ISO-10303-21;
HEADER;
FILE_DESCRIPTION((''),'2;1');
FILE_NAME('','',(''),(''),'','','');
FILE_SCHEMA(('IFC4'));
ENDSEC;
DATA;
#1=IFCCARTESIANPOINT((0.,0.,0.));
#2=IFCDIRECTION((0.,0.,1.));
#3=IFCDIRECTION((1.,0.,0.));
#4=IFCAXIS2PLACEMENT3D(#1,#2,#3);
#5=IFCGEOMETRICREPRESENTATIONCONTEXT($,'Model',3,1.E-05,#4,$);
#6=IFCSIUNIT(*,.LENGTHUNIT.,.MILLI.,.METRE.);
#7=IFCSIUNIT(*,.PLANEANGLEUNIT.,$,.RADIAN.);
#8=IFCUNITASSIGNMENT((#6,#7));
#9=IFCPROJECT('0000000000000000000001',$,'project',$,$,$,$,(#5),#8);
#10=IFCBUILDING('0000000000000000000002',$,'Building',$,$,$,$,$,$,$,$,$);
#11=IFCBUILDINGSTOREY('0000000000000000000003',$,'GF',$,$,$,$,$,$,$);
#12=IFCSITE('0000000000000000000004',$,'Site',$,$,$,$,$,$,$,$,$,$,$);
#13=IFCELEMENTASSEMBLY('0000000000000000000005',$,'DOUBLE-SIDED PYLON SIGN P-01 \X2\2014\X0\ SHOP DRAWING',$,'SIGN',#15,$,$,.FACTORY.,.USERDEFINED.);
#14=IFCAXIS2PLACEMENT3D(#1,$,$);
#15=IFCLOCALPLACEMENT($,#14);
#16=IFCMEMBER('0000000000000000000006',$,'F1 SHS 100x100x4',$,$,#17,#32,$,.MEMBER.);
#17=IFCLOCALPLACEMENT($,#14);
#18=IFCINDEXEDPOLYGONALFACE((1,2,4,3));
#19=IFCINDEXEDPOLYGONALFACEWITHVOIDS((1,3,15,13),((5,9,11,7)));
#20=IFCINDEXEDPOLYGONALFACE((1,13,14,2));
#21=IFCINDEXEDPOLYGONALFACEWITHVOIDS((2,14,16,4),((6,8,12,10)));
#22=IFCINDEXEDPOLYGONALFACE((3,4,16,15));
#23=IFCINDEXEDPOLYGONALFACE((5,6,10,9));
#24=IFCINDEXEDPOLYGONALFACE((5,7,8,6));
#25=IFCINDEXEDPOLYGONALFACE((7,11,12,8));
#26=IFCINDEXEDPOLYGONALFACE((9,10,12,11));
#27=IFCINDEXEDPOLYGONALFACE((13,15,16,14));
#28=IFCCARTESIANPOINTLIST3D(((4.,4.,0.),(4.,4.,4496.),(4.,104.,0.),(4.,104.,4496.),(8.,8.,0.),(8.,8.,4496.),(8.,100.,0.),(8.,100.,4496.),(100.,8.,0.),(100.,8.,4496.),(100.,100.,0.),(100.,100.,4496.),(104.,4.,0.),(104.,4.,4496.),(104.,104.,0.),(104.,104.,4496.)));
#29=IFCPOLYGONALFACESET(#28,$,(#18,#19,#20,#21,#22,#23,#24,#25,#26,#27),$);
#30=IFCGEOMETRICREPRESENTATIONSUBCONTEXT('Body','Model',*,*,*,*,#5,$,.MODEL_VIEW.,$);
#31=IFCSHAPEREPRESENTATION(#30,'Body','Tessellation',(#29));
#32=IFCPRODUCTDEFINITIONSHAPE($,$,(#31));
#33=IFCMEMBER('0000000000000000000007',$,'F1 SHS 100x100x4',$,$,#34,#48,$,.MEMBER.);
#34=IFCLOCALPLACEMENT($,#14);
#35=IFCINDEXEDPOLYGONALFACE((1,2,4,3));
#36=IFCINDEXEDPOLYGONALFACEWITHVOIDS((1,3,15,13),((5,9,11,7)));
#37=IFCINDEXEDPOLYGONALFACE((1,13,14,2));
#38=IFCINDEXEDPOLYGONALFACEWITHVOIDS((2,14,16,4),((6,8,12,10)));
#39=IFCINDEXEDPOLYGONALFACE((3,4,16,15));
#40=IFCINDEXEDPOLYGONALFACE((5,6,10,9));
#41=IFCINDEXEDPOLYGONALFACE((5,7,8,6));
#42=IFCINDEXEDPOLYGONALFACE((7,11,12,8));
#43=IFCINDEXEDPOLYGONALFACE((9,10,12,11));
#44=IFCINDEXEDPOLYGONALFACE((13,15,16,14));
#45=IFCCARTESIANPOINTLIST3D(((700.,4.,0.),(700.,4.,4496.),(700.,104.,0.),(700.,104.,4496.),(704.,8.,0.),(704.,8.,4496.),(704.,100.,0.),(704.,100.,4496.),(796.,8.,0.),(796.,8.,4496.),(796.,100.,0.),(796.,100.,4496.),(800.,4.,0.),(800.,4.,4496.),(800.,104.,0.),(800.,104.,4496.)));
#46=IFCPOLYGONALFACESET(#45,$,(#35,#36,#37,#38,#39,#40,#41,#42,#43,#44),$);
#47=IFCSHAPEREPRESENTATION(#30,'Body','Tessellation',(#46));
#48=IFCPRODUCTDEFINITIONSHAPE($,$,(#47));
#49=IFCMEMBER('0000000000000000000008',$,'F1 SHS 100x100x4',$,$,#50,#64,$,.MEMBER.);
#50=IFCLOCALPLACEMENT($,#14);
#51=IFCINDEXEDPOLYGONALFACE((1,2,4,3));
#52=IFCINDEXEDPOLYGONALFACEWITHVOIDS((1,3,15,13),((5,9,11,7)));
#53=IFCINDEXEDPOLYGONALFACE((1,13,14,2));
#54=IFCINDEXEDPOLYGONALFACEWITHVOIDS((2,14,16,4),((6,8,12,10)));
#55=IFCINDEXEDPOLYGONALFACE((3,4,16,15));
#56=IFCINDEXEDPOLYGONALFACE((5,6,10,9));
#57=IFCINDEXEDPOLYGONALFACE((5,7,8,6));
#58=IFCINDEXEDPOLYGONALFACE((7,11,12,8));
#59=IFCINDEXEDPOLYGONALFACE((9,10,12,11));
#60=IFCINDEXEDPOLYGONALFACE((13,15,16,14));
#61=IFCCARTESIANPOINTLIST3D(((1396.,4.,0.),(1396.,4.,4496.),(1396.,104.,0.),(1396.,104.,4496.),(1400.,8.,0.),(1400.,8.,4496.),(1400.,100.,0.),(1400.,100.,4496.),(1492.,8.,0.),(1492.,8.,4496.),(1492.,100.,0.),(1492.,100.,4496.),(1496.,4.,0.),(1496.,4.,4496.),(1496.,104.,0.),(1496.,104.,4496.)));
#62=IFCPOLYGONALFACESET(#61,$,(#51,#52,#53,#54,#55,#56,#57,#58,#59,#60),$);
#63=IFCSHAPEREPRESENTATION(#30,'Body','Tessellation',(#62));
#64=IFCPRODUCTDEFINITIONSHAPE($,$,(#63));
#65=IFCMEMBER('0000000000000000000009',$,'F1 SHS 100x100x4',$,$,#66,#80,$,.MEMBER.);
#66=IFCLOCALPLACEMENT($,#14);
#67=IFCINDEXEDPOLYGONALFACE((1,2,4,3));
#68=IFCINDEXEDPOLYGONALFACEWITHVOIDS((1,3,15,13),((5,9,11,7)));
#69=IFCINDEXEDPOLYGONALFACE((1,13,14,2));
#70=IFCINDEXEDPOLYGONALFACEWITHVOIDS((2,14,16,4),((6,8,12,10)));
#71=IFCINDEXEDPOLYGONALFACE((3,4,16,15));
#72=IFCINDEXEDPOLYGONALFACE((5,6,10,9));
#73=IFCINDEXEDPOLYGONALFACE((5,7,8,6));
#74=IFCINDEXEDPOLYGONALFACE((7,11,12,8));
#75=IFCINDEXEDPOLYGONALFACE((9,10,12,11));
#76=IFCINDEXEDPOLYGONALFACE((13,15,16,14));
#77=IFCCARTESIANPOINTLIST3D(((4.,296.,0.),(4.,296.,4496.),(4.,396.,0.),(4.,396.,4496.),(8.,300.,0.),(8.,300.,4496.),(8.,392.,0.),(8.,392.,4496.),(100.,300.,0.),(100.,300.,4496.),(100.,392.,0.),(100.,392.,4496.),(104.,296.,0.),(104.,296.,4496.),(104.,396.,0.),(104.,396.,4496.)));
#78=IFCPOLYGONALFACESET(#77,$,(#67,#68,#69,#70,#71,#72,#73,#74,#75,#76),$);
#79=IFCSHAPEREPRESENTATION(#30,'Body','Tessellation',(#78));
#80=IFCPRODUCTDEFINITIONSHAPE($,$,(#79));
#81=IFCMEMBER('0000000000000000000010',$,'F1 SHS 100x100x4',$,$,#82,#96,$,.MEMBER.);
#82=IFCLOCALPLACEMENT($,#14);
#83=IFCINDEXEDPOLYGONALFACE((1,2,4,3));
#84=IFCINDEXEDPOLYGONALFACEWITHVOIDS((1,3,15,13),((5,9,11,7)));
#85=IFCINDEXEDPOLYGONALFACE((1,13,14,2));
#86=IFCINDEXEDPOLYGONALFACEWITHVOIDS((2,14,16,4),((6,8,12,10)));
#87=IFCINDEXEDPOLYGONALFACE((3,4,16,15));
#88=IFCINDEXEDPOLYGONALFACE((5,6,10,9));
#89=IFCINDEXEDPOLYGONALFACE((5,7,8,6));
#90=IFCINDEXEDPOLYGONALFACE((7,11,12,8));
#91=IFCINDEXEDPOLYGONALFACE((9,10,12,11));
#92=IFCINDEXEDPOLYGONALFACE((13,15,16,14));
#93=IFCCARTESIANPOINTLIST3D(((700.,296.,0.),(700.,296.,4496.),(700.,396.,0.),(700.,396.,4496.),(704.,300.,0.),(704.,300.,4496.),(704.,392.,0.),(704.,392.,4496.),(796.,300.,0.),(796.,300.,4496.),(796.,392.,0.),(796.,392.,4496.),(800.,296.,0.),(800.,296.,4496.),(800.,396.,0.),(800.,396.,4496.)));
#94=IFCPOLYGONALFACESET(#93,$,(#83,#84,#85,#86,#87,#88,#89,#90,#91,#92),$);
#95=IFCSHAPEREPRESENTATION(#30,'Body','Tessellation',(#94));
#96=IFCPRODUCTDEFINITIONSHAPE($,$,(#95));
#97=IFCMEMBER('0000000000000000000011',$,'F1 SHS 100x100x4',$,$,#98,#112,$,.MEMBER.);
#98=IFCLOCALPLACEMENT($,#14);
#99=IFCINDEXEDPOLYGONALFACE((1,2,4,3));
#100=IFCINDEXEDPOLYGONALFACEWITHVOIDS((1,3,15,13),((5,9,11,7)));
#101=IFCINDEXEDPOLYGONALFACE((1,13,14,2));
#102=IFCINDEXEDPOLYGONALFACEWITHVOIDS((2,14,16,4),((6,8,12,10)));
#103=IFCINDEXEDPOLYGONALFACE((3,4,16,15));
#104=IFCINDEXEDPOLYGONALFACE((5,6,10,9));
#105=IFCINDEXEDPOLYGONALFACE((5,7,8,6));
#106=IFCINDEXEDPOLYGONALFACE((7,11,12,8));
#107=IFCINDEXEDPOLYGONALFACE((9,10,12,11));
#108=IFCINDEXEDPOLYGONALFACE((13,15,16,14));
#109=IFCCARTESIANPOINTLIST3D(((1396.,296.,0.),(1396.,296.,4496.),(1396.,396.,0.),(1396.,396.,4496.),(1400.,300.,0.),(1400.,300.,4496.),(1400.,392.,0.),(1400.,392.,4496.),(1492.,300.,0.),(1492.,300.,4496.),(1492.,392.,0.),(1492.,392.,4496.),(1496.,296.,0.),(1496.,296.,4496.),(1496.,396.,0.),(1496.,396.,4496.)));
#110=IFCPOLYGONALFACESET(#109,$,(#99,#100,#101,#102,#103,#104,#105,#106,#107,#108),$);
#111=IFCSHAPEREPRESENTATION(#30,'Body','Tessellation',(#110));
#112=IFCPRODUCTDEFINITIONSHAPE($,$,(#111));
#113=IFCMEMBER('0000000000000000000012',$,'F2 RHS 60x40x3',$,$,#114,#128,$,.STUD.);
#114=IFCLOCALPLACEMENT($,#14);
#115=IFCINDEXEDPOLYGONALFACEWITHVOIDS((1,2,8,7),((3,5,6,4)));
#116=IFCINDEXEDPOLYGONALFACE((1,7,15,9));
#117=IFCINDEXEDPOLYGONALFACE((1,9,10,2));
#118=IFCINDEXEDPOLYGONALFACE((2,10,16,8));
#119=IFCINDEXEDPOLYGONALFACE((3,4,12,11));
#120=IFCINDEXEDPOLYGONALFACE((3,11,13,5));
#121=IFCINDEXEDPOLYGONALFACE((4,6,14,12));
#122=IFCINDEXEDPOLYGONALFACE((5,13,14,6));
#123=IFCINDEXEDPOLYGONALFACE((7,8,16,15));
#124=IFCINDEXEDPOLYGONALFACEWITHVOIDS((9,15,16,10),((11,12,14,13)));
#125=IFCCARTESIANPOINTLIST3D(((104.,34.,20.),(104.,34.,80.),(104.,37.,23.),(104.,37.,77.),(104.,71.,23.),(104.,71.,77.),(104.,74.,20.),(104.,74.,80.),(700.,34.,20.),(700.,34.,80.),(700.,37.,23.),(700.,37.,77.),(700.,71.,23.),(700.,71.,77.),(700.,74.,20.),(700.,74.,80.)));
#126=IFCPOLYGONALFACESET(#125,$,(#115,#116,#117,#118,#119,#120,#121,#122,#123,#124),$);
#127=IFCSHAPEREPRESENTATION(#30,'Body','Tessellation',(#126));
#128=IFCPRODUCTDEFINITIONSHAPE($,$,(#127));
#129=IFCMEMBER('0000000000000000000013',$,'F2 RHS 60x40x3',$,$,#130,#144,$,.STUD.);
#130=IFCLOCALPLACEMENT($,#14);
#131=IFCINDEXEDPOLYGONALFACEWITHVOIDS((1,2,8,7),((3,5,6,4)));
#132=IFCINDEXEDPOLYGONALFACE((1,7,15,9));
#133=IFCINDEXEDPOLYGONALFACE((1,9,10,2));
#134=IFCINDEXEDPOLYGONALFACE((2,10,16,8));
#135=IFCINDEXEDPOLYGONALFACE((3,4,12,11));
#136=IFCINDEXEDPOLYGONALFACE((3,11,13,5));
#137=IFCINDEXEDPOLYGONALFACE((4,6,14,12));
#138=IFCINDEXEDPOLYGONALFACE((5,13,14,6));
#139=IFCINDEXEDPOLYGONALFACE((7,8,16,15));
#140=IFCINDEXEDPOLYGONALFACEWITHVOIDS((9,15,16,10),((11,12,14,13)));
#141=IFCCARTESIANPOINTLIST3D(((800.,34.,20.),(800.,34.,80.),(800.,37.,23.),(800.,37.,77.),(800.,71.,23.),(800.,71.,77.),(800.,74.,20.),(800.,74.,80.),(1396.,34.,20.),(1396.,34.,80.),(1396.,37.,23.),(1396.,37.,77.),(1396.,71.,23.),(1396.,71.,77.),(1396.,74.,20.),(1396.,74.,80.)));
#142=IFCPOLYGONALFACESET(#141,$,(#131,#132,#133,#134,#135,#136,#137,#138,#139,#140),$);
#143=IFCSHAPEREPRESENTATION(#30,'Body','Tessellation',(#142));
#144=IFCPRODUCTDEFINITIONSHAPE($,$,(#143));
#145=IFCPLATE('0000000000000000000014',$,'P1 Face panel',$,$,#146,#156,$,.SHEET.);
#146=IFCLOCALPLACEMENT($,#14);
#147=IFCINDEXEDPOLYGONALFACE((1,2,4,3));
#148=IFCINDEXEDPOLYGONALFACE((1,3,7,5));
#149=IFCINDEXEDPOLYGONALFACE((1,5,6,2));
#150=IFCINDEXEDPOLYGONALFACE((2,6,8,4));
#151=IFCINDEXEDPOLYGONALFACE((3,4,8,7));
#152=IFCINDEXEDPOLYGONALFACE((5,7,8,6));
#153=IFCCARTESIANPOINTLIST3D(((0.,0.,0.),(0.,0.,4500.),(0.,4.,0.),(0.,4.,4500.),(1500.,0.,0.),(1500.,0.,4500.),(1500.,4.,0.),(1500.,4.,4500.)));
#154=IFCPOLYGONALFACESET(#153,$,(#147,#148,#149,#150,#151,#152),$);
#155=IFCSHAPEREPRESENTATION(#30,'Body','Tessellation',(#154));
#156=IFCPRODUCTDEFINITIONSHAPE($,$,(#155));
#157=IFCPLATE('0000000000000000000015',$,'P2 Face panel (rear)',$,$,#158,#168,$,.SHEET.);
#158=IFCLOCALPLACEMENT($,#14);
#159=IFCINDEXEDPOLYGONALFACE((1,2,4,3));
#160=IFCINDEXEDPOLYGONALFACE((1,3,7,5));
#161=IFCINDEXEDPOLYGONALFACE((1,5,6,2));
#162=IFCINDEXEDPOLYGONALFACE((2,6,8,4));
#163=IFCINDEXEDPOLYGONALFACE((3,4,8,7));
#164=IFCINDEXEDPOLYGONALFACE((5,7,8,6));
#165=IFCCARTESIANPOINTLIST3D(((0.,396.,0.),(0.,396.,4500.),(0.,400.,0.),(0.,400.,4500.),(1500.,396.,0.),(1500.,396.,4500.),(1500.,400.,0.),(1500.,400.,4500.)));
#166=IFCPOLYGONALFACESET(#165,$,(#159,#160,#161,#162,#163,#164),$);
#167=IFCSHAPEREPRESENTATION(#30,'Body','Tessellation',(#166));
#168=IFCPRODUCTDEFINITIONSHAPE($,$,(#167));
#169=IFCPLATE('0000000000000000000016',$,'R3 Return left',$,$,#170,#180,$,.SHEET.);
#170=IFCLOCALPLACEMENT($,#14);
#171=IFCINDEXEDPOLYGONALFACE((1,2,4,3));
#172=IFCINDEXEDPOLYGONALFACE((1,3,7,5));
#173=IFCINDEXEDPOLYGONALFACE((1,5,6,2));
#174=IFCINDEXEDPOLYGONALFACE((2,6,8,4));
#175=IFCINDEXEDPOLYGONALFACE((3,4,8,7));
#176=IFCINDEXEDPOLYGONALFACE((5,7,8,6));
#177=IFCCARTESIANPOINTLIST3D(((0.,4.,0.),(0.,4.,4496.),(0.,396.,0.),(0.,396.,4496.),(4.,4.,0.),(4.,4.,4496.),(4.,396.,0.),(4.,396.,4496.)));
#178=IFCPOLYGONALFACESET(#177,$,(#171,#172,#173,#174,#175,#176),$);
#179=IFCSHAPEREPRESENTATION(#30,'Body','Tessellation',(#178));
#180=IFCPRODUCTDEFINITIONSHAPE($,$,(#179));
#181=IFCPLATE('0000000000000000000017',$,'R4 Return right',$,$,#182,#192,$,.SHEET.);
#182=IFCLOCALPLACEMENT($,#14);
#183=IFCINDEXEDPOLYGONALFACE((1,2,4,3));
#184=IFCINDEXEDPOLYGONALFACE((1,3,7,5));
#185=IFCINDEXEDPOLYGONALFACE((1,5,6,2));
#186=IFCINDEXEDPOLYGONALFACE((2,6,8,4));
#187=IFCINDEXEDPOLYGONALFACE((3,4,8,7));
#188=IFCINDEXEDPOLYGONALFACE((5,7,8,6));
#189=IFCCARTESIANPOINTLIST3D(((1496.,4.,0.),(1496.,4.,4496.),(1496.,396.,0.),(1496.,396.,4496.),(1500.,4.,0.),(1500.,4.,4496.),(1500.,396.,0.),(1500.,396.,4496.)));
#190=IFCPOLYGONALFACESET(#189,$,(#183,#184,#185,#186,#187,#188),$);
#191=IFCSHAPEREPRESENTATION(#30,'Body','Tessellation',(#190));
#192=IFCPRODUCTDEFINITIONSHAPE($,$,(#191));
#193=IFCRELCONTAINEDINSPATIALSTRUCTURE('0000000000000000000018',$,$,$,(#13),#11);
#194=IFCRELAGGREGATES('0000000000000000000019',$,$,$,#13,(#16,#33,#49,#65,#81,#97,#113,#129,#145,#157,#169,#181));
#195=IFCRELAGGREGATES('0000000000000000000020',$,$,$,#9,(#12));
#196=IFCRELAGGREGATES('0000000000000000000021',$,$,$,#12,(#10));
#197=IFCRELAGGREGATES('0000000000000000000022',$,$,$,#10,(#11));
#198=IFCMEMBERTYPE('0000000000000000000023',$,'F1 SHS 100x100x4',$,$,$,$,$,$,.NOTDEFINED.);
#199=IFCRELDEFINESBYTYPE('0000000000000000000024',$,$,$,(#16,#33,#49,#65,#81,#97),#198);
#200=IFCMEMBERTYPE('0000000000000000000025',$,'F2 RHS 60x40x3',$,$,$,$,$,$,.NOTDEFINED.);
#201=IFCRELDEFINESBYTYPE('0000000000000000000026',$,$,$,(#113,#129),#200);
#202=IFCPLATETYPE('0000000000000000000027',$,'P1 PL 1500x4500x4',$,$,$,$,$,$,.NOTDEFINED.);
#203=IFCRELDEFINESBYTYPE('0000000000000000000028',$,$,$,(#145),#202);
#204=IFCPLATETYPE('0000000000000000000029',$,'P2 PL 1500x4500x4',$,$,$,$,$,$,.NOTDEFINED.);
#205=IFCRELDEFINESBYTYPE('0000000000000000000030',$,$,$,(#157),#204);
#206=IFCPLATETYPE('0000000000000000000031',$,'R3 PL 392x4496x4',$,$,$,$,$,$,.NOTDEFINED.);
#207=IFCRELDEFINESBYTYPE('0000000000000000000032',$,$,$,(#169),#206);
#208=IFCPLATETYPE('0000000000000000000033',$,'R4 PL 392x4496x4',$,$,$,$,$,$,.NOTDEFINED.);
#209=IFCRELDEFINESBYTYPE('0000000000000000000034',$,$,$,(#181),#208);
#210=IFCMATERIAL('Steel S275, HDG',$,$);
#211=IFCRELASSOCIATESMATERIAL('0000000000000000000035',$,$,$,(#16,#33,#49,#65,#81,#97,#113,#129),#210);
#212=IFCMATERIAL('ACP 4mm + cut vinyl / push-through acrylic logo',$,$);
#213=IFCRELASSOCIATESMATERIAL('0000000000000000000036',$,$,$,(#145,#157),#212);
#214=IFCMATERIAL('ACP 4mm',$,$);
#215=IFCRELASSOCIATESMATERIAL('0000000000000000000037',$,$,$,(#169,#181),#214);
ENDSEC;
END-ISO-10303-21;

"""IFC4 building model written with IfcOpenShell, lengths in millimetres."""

from ifc_helpers import new_model, si_unit, frame, frame_2d, origin, origin_with_axes, place, context, subcontext, project, spatial, rectangle, hollow_rectangle, extrude, material, type_object, element, aggregate, save


model = new_model("IFC4")

# Units and contexts
model_context = context("Model", 3, precision=1e-05, world=origin_with_axes())
body_context = subcontext(model_context, "Body", "Model", "MODEL_VIEW")
ifc_project = project(units=[si_unit("LENGTHUNIT", "METRE", prefix="MILLI"), si_unit("PLANEANGLEUNIT", "RADIAN")], contexts=[model_context])

# Site, building, storey
site = spatial("IfcSite", under=ifc_project, Name="Site")
building = spatial("IfcBuilding", under=site, Name="Building")
storey = spatial("IfcBuildingStorey", under=building, Name="GF")

# Element assembly, members, plates
assembly_placement = place(None, origin_with_axes())
assembly = element("IfcElementAssembly", 1, at=assembly_placement, inside=storey, Name="DOUBLE-SIDED PYLON SIGN P-01 — SHOP DRAWING", ObjectType="SIGN", AssemblyPlace="FACTORY", PredefinedType="USERDEFINED")
ifc_material_1 = material(Name="Steel S275, HDG")
member_type_1 = type_object("IfcMemberType", Name="F1 SHS 100x100x4", PredefinedType="NOTDEFINED")
member_1_placement = place(assembly_placement, frame((54.0, 54.0, 0.0), z_axis=(0.0, 0.0, 1.0), x_axis=(1.0, 0.0, 0.0)))
member_1 = element("IfcMember", 2, at=member_1_placement, type_object=member_type_1, material=ifc_material_1, Name="F1 SHS 100x100x4", PredefinedType="MEMBER", context=body_context, shape_type="SweptSolid", body=[
    extrude(hollow_rectangle(XDim=100.0, YDim=100.0, WallThickness=4.0), origin(), (0.0, 0.0, 1.0), 4496.0),
])
member_2_placement = place(assembly_placement, frame((750.0, 54.0, 0.0), z_axis=(0.0, 0.0, 1.0), x_axis=(1.0, 0.0, 0.0)))
member_2 = element("IfcMember", 3, at=member_2_placement, type_object=member_type_1, material=ifc_material_1, Name="F1 SHS 100x100x4", PredefinedType="MEMBER", context=body_context, shape_type="SweptSolid", body=[
    extrude(hollow_rectangle(XDim=100.0, YDim=100.0, WallThickness=4.0), origin(), (0.0, 0.0, 1.0), 4496.0),
])
member_3_placement = place(assembly_placement, frame((1446.0, 54.0, 0.0), z_axis=(0.0, 0.0, 1.0), x_axis=(1.0, 0.0, 0.0)))
member_3 = element("IfcMember", 4, at=member_3_placement, type_object=member_type_1, material=ifc_material_1, Name="F1 SHS 100x100x4", PredefinedType="MEMBER", context=body_context, shape_type="SweptSolid", body=[
    extrude(hollow_rectangle(XDim=100.0, YDim=100.0, WallThickness=4.0), origin(), (0.0, 0.0, 1.0), 4496.0),
])
member_4_placement = place(assembly_placement, frame((54.0, 346.0, 0.0), z_axis=(0.0, 0.0, 1.0), x_axis=(1.0, 0.0, 0.0)))
member_4 = element("IfcMember", 5, at=member_4_placement, type_object=member_type_1, material=ifc_material_1, Name="F1 SHS 100x100x4", PredefinedType="MEMBER", context=body_context, shape_type="SweptSolid", body=[
    extrude(hollow_rectangle(XDim=100.0, YDim=100.0, WallThickness=4.0), origin(), (0.0, 0.0, 1.0), 4496.0),
])
member_5_placement = place(assembly_placement, frame((750.0, 346.0, 0.0), z_axis=(0.0, 0.0, 1.0), x_axis=(1.0, 0.0, 0.0)))
member_5 = element("IfcMember", 6, at=member_5_placement, type_object=member_type_1, material=ifc_material_1, Name="F1 SHS 100x100x4", PredefinedType="MEMBER", context=body_context, shape_type="SweptSolid", body=[
    extrude(hollow_rectangle(XDim=100.0, YDim=100.0, WallThickness=4.0), origin(), (0.0, 0.0, 1.0), 4496.0),
])
member_6_placement = place(assembly_placement, frame((1446.0, 346.0, 0.0), z_axis=(0.0, 0.0, 1.0), x_axis=(1.0, 0.0, 0.0)))
member_6 = element("IfcMember", 7, at=member_6_placement, type_object=member_type_1, material=ifc_material_1, Name="F1 SHS 100x100x4", PredefinedType="MEMBER", context=body_context, shape_type="SweptSolid", body=[
    extrude(hollow_rectangle(XDim=100.0, YDim=100.0, WallThickness=4.0), origin(), (0.0, 0.0, 1.0), 4496.0),
])
member_type_2 = type_object("IfcMemberType", Name="F2 RHS 60x40x3", PredefinedType="NOTDEFINED")
member_7_placement = place(assembly_placement, frame((104.0, 54.0, 50.0), z_axis=(1.0, 0.0, 0.0), x_axis=(0.0, 0.0, 1.0)))
member_7 = element("IfcMember", 8, at=member_7_placement, type_object=member_type_2, material=ifc_material_1, Name="F2 RHS 60x40x3", PredefinedType="STUD", context=body_context, shape_type="SweptSolid", body=[
    extrude(hollow_rectangle(XDim=60.0, YDim=40.0, WallThickness=3.0), origin(), (0.0, 0.0, 1.0), 596.0),
])
member_8_placement = place(assembly_placement, frame((800.0, 54.0, 50.0), z_axis=(1.0, 0.0, 0.0), x_axis=(0.0, 0.0, 1.0)))
member_8 = element("IfcMember", 9, at=member_8_placement, type_object=member_type_2, material=ifc_material_1, Name="F2 RHS 60x40x3", PredefinedType="STUD", context=body_context, shape_type="SweptSolid", body=[
    extrude(hollow_rectangle(XDim=60.0, YDim=40.0, WallThickness=3.0), origin(), (0.0, 0.0, 1.0), 596.0),
])
ifc_material_2 = material(Name="ACP 4mm + cut vinyl / push-through acrylic logo")
plate_type_1 = type_object("IfcPlateType", Name="P1 PL 1500x4500x4", PredefinedType="NOTDEFINED")
plate_1_placement = place(assembly_placement, frame((0.0, 4.0, 0.0), z_axis=(0.0, -1.0, 0.0), x_axis=(1.0, 0.0, 0.0)))
plate_1 = element("IfcPlate", 10, at=plate_1_placement, type_object=plate_type_1, material=ifc_material_2, Name="P1 Face panel", PredefinedType="SHEET", context=body_context, shape_type="SweptSolid", body=[
    extrude(rectangle(XDim=1500.0, YDim=4500.0, at=frame_2d((750.0, 2250.0))), origin(), (0.0, 0.0, 1.0), 4.0),
])
plate_type_2 = type_object("IfcPlateType", Name="P2 PL 1500x4500x4", PredefinedType="NOTDEFINED")
plate_2_placement = place(assembly_placement, frame((1500.0, 396.0, 0.0), z_axis=(0.0, 1.0, 0.0), x_axis=(-1.0, 0.0, 0.0)))
plate_2 = element("IfcPlate", 11, at=plate_2_placement, type_object=plate_type_2, material=ifc_material_2, Name="P2 Face panel (rear)", PredefinedType="SHEET", context=body_context, shape_type="SweptSolid", body=[
    extrude(rectangle(XDim=1500.0, YDim=4500.0, at=frame_2d((750.0, 2250.0))), origin(), (0.0, 0.0, 1.0), 4.0),
])
ifc_material_3 = material(Name="ACP 4mm")
plate_type_3 = type_object("IfcPlateType", Name="R3 PL 392x4496x4", PredefinedType="NOTDEFINED")
plate_3_placement = place(assembly_placement, frame((0.0, 4.0, 0.0), z_axis=(1.0, 0.0, 0.0), x_axis=(0.0, 1.0, 0.0)))
plate_3 = element("IfcPlate", 12, at=plate_3_placement, type_object=plate_type_3, material=ifc_material_3, Name="R3 Return left", PredefinedType="SHEET", context=body_context, shape_type="SweptSolid", body=[
    extrude(rectangle(XDim=392.0, YDim=4496.0, at=frame_2d((196.0, 2248.0))), origin(), (0.0, 0.0, 1.0), 4.0),
])
plate_type_4 = type_object("IfcPlateType", Name="R4 PL 392x4496x4", PredefinedType="NOTDEFINED")
plate_4_placement = place(assembly_placement, frame((1496.0, 4.0, 0.0), z_axis=(1.0, 0.0, 0.0), x_axis=(0.0, 1.0, 0.0)))
plate_4 = element("IfcPlate", 13, at=plate_4_placement, type_object=plate_type_4, material=ifc_material_3, Name="R4 Return right", PredefinedType="SHEET", context=body_context, shape_type="SweptSolid", body=[
    extrude(rectangle(XDim=392.0, YDim=4496.0, at=frame_2d((196.0, 2248.0))), origin(), (0.0, 0.0, 1.0), 4.0),
])
aggregate(assembly, [member_1, member_2, member_3, member_4, member_5, member_6, member_7, member_8, plate_1, plate_2, plate_3, plate_4])

save(model, "model.ifc")
